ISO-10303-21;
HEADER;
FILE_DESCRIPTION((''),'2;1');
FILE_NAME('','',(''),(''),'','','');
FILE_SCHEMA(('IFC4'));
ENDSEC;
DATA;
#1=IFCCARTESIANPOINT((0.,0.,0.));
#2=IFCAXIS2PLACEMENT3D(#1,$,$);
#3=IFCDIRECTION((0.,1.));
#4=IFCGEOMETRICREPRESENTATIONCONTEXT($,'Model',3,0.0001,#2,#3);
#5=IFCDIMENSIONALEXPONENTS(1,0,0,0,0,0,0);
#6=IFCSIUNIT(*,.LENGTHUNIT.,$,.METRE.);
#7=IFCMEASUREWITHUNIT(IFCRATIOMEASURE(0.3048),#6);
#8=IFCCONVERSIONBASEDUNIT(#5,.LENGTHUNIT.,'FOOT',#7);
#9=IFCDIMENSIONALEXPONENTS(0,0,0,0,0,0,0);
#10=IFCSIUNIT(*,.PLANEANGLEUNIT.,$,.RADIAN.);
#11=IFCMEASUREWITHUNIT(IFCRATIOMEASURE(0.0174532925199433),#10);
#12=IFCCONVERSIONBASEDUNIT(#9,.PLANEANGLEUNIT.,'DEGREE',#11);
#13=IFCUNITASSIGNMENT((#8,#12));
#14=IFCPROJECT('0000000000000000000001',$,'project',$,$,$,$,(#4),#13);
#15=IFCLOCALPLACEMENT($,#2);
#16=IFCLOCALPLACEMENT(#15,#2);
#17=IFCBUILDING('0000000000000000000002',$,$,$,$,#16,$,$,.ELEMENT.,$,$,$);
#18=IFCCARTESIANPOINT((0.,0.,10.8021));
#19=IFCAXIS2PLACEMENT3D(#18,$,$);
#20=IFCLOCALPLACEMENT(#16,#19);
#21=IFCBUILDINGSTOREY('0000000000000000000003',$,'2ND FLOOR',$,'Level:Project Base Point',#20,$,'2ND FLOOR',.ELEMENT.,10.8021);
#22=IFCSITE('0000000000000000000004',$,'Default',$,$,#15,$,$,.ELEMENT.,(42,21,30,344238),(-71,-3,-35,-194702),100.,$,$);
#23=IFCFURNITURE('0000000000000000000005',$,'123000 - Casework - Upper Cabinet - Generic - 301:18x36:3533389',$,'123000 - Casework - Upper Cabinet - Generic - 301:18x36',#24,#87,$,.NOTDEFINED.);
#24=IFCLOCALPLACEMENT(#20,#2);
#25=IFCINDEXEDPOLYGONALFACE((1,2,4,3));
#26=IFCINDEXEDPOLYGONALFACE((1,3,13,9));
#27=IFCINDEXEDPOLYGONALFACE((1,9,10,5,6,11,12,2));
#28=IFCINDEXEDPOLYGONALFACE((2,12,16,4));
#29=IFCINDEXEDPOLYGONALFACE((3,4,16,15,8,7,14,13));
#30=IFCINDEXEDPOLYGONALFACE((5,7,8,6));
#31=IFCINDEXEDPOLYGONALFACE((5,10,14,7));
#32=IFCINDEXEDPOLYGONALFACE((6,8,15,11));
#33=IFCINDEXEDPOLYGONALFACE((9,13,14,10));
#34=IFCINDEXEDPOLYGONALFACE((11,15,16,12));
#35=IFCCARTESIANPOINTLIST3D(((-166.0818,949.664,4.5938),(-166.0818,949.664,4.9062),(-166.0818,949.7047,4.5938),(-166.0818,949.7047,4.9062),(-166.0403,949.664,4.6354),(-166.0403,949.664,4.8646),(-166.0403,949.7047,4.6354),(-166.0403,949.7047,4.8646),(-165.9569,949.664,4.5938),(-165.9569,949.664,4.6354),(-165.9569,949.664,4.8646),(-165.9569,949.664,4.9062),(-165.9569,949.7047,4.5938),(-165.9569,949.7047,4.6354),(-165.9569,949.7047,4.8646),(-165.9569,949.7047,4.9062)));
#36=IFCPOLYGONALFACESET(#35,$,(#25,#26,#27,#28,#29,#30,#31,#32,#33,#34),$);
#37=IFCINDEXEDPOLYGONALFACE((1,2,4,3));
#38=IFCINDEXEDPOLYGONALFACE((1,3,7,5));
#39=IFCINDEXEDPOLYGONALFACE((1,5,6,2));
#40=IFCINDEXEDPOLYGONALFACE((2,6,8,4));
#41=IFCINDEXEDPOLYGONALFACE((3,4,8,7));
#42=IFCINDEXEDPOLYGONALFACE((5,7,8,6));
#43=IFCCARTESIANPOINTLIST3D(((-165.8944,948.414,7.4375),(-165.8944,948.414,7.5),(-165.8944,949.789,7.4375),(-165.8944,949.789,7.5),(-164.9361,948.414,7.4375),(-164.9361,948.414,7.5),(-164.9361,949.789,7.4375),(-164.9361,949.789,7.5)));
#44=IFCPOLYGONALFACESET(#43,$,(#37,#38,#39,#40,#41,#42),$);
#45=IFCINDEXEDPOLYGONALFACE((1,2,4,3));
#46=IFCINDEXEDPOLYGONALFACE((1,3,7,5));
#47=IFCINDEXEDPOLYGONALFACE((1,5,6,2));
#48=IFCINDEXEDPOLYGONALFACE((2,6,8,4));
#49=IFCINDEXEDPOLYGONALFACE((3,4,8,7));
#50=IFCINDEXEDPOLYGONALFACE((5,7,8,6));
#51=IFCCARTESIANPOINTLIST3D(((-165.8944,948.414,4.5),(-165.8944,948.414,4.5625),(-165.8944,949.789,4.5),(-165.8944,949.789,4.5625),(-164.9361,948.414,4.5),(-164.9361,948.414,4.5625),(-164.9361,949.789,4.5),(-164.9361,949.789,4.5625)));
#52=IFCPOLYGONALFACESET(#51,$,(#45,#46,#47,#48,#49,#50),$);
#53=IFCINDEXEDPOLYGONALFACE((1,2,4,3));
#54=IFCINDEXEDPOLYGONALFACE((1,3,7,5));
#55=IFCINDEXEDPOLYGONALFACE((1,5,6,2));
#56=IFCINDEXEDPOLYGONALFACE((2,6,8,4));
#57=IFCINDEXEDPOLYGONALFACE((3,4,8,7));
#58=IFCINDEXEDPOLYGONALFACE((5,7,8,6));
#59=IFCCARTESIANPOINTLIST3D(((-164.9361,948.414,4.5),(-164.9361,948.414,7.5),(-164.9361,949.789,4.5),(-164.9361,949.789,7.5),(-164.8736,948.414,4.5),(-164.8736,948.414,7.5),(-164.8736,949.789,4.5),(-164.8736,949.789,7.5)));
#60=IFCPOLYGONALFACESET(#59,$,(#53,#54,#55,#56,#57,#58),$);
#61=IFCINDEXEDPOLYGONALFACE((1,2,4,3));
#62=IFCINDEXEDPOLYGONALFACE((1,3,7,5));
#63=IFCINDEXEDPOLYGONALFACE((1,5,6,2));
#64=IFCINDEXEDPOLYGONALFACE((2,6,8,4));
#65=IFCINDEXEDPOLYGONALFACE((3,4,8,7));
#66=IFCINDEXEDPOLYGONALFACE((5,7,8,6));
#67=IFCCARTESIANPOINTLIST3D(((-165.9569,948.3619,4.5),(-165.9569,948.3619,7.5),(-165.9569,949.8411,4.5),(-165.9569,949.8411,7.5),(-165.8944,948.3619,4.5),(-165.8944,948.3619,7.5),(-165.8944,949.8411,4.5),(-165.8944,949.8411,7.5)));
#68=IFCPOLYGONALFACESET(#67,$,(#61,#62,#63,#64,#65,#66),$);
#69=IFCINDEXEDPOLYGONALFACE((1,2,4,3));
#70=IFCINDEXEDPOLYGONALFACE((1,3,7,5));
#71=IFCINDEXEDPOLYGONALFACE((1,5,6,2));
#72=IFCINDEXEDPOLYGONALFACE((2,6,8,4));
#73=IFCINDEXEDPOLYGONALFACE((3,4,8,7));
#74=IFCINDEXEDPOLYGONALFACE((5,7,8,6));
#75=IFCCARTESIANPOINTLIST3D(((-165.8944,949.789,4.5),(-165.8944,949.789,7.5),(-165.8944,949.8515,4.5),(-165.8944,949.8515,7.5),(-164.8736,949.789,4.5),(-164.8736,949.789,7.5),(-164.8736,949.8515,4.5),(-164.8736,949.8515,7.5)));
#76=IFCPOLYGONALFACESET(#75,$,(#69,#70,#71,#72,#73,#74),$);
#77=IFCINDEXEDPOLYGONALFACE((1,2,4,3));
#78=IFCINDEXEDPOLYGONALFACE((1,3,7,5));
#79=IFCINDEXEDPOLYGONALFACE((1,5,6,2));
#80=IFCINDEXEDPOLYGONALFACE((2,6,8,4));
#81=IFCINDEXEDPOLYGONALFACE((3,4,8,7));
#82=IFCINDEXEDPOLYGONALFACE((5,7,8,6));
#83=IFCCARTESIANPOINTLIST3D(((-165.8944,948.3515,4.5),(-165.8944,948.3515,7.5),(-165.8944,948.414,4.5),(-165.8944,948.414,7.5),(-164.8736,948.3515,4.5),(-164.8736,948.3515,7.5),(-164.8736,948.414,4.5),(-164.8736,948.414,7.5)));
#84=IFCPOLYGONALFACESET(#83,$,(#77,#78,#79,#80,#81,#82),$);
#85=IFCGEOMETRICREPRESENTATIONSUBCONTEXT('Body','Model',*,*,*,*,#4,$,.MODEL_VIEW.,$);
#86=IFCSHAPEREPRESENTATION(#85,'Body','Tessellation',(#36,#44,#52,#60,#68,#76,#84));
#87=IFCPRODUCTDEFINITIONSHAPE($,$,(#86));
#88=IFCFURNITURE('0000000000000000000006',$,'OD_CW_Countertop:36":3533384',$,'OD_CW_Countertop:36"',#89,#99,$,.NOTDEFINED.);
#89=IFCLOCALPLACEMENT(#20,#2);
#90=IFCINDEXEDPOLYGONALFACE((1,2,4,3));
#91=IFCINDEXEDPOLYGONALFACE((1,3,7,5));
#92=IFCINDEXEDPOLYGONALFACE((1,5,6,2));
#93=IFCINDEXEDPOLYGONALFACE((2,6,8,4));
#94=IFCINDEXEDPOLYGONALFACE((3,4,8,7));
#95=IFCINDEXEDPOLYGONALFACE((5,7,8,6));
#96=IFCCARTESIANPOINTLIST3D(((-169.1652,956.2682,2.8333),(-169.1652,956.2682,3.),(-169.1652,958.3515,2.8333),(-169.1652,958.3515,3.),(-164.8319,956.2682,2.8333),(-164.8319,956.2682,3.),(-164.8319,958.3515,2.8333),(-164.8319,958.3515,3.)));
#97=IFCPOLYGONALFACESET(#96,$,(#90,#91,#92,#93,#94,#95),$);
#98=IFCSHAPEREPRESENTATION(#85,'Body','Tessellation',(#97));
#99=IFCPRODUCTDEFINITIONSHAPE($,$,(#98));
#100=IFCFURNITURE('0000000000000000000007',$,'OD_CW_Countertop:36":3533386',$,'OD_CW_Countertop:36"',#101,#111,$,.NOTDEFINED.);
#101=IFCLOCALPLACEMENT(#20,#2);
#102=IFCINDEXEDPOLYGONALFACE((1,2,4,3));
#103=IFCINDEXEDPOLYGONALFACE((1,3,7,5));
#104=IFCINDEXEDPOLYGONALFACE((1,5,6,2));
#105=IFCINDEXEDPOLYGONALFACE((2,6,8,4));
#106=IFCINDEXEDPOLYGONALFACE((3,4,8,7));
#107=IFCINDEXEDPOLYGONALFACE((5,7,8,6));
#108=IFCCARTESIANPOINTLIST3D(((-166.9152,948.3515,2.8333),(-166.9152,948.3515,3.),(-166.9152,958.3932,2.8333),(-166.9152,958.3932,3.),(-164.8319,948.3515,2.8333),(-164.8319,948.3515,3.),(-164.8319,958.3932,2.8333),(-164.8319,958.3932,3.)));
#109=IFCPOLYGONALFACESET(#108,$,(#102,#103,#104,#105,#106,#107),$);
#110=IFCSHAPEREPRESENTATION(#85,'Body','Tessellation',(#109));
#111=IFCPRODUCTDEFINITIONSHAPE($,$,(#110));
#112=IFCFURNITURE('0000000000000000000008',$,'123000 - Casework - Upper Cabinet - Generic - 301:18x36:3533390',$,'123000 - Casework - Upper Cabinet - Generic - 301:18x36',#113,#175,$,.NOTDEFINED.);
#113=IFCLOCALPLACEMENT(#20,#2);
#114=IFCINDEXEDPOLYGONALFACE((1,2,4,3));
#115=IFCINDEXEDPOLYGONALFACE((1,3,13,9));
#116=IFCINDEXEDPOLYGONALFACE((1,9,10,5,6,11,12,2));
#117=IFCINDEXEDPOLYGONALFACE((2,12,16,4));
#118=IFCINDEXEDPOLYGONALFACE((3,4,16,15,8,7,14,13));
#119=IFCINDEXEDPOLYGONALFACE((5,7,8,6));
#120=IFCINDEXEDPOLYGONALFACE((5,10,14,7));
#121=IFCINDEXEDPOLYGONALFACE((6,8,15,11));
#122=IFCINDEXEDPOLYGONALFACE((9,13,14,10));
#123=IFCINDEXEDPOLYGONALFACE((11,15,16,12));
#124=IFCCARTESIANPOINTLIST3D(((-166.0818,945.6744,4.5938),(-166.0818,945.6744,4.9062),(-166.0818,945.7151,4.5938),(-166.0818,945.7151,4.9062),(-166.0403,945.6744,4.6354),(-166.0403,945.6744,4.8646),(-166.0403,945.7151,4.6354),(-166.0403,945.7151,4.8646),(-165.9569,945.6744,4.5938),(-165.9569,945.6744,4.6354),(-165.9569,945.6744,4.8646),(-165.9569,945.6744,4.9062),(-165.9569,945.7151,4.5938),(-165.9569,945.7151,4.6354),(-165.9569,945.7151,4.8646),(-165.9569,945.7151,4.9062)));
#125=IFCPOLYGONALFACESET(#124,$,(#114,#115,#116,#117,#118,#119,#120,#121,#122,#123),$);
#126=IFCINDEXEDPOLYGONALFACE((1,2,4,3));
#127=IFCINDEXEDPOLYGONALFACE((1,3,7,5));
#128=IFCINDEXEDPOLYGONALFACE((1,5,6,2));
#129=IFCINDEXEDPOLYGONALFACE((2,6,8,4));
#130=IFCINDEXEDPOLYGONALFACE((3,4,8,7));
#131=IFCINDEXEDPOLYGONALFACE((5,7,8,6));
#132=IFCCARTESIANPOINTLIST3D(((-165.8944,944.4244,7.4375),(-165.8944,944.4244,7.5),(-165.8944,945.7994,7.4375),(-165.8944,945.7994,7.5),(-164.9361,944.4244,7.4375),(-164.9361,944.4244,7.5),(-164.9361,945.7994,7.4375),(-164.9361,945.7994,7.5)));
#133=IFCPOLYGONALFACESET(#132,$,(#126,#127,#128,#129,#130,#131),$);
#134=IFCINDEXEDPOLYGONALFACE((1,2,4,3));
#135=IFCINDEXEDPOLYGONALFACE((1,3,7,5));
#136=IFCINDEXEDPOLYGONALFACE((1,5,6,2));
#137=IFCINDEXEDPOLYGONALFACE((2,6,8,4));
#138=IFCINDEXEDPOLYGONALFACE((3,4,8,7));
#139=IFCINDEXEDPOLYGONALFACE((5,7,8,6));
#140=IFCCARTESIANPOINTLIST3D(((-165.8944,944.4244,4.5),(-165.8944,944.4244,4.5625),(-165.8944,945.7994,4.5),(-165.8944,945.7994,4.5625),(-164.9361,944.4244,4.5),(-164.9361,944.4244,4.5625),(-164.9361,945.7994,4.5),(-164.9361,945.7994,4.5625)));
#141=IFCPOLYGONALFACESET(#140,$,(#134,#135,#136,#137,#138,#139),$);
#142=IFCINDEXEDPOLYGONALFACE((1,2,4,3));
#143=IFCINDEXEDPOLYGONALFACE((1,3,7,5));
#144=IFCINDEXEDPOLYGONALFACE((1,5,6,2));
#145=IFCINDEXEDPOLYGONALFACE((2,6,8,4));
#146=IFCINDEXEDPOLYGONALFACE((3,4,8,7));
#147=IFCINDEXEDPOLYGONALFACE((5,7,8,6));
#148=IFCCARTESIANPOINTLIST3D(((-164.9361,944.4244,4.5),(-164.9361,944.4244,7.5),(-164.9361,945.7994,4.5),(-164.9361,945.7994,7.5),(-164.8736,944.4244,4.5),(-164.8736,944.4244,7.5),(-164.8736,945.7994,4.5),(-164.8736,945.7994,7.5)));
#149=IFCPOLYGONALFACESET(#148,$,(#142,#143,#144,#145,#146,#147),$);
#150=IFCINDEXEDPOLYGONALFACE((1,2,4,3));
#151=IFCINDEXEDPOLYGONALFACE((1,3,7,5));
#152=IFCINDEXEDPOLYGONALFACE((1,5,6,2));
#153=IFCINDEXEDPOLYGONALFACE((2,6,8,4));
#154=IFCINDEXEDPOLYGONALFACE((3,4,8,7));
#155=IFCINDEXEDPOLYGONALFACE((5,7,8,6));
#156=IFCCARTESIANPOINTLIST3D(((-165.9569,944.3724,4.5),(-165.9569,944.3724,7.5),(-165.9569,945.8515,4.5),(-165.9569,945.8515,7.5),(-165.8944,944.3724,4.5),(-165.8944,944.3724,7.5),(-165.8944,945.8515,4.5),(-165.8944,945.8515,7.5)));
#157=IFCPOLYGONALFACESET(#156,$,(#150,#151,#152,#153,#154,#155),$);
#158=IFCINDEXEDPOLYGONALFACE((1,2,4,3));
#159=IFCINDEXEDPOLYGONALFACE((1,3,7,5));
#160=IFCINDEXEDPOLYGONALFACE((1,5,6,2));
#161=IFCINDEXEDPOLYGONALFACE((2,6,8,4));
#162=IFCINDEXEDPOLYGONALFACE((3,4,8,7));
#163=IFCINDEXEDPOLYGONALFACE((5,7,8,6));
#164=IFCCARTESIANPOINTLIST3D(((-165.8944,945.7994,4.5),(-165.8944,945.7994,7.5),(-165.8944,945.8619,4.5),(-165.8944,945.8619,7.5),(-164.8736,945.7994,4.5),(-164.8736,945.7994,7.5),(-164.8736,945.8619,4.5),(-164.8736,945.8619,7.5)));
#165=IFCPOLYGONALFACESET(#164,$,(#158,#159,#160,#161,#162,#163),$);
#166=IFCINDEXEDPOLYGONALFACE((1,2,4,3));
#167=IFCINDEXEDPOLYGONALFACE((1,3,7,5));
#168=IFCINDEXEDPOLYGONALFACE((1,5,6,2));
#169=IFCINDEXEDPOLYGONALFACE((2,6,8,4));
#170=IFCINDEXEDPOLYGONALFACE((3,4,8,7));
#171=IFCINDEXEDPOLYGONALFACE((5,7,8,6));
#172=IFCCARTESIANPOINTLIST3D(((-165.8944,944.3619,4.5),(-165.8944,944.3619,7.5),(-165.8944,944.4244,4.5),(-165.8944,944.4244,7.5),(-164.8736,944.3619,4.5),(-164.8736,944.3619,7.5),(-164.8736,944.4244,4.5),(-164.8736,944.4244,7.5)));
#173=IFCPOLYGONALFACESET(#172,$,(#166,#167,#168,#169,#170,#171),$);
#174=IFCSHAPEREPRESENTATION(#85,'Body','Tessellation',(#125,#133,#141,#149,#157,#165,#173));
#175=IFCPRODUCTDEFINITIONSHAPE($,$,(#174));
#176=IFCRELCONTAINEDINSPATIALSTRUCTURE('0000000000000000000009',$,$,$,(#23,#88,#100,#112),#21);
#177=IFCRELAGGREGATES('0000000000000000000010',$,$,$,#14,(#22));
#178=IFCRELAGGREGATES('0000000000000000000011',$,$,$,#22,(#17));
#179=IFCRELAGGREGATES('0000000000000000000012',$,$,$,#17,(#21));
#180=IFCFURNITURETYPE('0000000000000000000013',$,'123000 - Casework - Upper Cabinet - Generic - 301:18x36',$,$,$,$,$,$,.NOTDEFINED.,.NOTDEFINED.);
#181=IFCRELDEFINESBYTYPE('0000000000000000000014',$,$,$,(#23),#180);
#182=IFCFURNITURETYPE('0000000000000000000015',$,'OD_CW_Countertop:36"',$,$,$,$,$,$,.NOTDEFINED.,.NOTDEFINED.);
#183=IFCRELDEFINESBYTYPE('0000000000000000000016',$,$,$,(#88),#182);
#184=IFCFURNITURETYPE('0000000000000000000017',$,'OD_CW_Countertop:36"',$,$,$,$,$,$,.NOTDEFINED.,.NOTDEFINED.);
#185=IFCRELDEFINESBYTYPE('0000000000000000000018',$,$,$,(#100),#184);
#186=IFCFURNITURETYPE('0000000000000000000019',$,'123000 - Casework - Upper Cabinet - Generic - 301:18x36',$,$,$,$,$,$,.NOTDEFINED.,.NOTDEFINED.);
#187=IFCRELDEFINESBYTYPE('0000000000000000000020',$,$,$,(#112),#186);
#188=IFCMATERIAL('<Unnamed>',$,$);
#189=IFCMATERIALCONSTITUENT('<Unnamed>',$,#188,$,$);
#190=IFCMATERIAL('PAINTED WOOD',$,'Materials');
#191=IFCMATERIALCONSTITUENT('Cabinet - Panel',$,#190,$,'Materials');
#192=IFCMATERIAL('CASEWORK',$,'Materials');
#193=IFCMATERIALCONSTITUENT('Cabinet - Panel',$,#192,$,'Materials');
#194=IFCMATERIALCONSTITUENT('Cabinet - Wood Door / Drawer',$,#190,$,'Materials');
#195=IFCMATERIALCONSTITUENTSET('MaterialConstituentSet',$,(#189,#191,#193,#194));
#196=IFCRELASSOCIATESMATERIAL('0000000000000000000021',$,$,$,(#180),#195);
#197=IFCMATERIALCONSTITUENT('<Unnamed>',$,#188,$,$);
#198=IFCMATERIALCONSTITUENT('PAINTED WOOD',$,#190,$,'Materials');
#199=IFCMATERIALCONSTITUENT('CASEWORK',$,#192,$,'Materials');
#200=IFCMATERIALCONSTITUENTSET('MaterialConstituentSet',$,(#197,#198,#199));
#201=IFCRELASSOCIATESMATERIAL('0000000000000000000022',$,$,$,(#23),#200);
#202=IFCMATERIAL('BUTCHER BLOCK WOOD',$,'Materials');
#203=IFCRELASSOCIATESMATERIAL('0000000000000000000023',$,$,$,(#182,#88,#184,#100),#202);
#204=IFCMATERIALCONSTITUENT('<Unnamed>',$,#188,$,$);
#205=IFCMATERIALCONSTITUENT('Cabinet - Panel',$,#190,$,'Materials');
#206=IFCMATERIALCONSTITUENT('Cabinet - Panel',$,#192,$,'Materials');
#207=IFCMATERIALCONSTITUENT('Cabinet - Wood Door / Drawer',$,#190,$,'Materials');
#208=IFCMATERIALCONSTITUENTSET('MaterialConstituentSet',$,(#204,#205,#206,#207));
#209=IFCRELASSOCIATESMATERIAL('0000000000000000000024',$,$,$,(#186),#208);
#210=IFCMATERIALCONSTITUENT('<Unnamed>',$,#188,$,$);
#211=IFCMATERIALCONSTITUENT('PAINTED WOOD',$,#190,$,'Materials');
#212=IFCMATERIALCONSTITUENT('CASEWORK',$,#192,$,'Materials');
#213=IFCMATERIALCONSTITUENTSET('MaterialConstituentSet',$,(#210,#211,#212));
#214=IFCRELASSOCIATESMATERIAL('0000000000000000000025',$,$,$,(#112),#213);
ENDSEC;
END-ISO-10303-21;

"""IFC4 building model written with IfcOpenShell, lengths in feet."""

from ifc_helpers import new_model, entity, si_unit, converted_unit, direction, frame, frame_2d, origin, origin_2d_with_axis, place, context, subcontext, project, spatial, polyline, rectangle, outline, extrude, source, transform, mapped, material, constituent, constituent_set, type_object, type_shapes, element, save


model = new_model("IFC4")

# Units and contexts
model_context = context("Model", 3, precision=0.0001, world=origin(), true_north=direction((0.0, 1.0)))
body_context = subcontext(model_context, "Body", "Model", "MODEL_VIEW")
ifc_project = project(units=[converted_unit("LENGTHUNIT", "FOOT", entity("IfcRatioMeasure", 0.3048), si_unit("LENGTHUNIT", "METRE"), dimensions=[1, 0, 0, 0, 0, 0, 0]), converted_unit("PLANEANGLEUNIT", "DEGREE", entity("IfcRatioMeasure", 0.0174532925199433), si_unit("PLANEANGLEUNIT", "RADIAN"), dimensions=[0, 0, 0, 0, 0, 0, 0])], contexts=[model_context])

# Site, building, storey
site_placement = place(None, origin())
site = spatial("IfcSite", under=ifc_project, at=site_placement, Name="Default", CompositionType="ELEMENT", RefLatitude=(42, 21, 30, 344238), RefLongitude=(-71, -3, -35, -194702), RefElevation=100.0)
building_placement = place(site_placement, origin())
building = spatial("IfcBuilding", under=site, at=building_placement, CompositionType="ELEMENT")
storey_placement = place(building_placement, frame((0.0, 0.0, 10.8021)))
storey = spatial("IfcBuildingStorey", under=building, at=storey_placement, Name="2ND FLOOR", ObjectType="Level:Project Base Point", LongName="2ND FLOOR", CompositionType="ELEMENT", Elevation=10.8021)

# Shared definitions
ifc_material_1 = material(Name="PAINTED WOOD", Category="Materials")
ifc_material_2 = material(Name="CASEWORK", Category="Materials")

# Furniture
ifc_material_3 = material(Name="<Unnamed>")
ifc_constituent_1 = constituent(ifc_material_3, Name="<Unnamed>")
ifc_constituent_2 = constituent(ifc_material_1, Name="PAINTED WOOD", Category="Materials")
ifc_constituent_3 = constituent(ifc_material_2, Name="CASEWORK", Category="Materials")
ifc_constituent_set_1 = constituent_set(constituents=[ifc_constituent_1, ifc_constituent_2, ifc_constituent_3], Name="MaterialConstituentSet")
ifc_constituent_4 = constituent(ifc_material_3, Name="<Unnamed>")
ifc_constituent_5 = constituent(ifc_material_1, Name="Cabinet - Panel", Category="Materials")
ifc_constituent_6 = constituent(ifc_material_2, Name="Cabinet - Panel", Category="Materials")
ifc_constituent_7 = constituent(ifc_material_1, Name="Cabinet - Wood Door / Drawer", Category="Materials")
ifc_constituent_set_2 = constituent_set(constituents=[ifc_constituent_4, ifc_constituent_5, ifc_constituent_6, ifc_constituent_7], Name="MaterialConstituentSet")
furniture_type_1 = type_object("IfcFurnitureType", Name="123000 - Casework - Upper Cabinet - Generic - 301:18x36", AssemblyPlace="NOTDEFINED", PredefinedType="NOTDEFINED", material=ifc_constituent_set_2)
shared_shape_1 = source(origin(), body_context, "Body", "SweptSolid", [
    extrude(outline(polyline([(0.1146, -0.0521), (0.1562, -0.0521), (0.1562, 0.0729), (-0.1562, 0.0729), (-0.1562, -0.0521), (-0.1146, -0.0521), (-0.1146, 0.0313), (0.1146, 0.0313), (0.1146, -0.0521)])), frame((0.1468, 0.0729, 0.25), z_axis=(1.0, 0.0, 0.0), x_axis=(0.0, 0.0, 1.0)), (0.0, 0.0, 1.0), 0.0407),
    extrude(rectangle(XDim=1.375, YDim=0.9583, at=frame_2d((0.0, 0.0), x_axis=(1.0, 0.0))), frame((0.75, 0.6666, 2.9375), z_axis=(0.0, 0.0, 1.0), x_axis=(-1.0, 0.0, 0.0)), (0.0, 0.0, 1.0), 0.0625),
    extrude(rectangle(XDim=1.375, YDim=0.9583, at=frame_2d((0.0, 0.0), x_axis=(1.0, 0.0))), frame((0.75, 0.6666, 0.0), z_axis=(0.0, 0.0, 1.0), x_axis=(-1.0, 0.0, 0.0)), (0.0, 0.0, 1.0), 0.0625),
    extrude(rectangle(XDim=0.0625, YDim=1.375, at=origin_2d_with_axis()), frame((0.75, 1.177, 0.0), z_axis=(0.0, 0.0, 1.0), x_axis=(0.0, 1.0, 0.0)), (0.0, 0.0, 1.0), 3.0),
    extrude(rectangle(XDim=0.0625, YDim=1.4792, at=origin_2d_with_axis()), frame((0.75, 0.1562, 0.0), z_axis=(0.0, 0.0, 1.0), x_axis=(0.0, -1.0, 0.0)), (0.0, 0.0, 1.0), 3.0),
    extrude(rectangle(XDim=0.0625, YDim=1.0208, at=origin_2d_with_axis()), frame((0.0312, 0.6979, 0.0), z_axis=(0.0, 0.0, 1.0), x_axis=(-1.0, 0.0, 0.0)), (0.0, 0.0, 1.0), 3.0),
    extrude(rectangle(XDim=0.0625, YDim=1.0208, at=origin_2d_with_axis()), frame((1.4688, 0.6979, 0.0), z_axis=(0.0, 0.0, 1.0), x_axis=(-1.0, 0.0, 0.0)), (0.0, 0.0, 1.0), 3.0),
])
type_shapes(furniture_type_1, [shared_shape_1])
furniture_1_placement = place(storey_placement, frame((-166.0818, 949.8515, 4.5), z_axis=(0.0, 0.0, 1.0), x_axis=(0.0, -1.0, 0.0)))
element("IfcFurniture", 1, at=furniture_1_placement, inside=storey, type_object=furniture_type_1, material=ifc_constituent_set_1, Name="123000 - Casework - Upper Cabinet - Generic - 301:18x36:3533389", ObjectType="123000 - Casework - Upper Cabinet - Generic - 301:18x36", PredefinedType="NOTDEFINED", context=body_context, shape_type="MappedRepresentation", body=[
    mapped(shared_shape_1, transform((0.0, 0.0, 0.0), scale=1.0)),
])
ifc_material_4 = material(Name="BUTCHER BLOCK WOOD", Category="Materials")
furniture_type_2 = type_object("IfcFurnitureType", Name="OD_CW_Countertop:36\"", AssemblyPlace="NOTDEFINED", PredefinedType="NOTDEFINED", material=ifc_material_4)
shared_shape_2 = source(origin(), body_context, "Body", "SweptSolid", [
    extrude(rectangle(XDim=2.0833, YDim=4.3333, at=frame_2d((0.0, 0.0), x_axis=(1.0, 0.0))), frame((2.1667, 1.0417, 0.0), z_axis=(0.0, 0.0, 1.0), x_axis=(0.0, -1.0, 0.0)), (0.0, 0.0, 1.0), 0.1667),
])
type_shapes(furniture_type_2, [shared_shape_2])
furniture_2_placement = place(storey_placement, frame((-169.1652, 956.2682, 2.8333)))
element("IfcFurniture", 2, at=furniture_2_placement, inside=storey, type_object=furniture_type_2, material=ifc_material_4, Name="OD_CW_Countertop:36\":3533384", ObjectType="OD_CW_Countertop:36\"", PredefinedType="NOTDEFINED", context=body_context, shape_type="MappedRepresentation", body=[
    mapped(shared_shape_2, transform((0.0, 0.0, 0.0), scale=1.0)),
])
furniture_type_3 = type_object("IfcFurnitureType", Name="OD_CW_Countertop:36\"", AssemblyPlace="NOTDEFINED", PredefinedType="NOTDEFINED", material=ifc_material_4)
shared_shape_3 = source(origin(), body_context, "Body", "SweptSolid", [
    extrude(rectangle(XDim=2.0833, YDim=10.0417, at=origin_2d_with_axis()), frame((5.0208, 1.0417, 0.0), z_axis=(0.0, 0.0, 1.0), x_axis=(0.0, -1.0, 0.0)), (0.0, 0.0, 1.0), 0.1667),
])
type_shapes(furniture_type_3, [shared_shape_3])
furniture_3_placement = place(storey_placement, frame((-166.9152, 958.3932, 2.8333), z_axis=(0.0, 0.0, 1.0), x_axis=(0.0, -1.0, 0.0)))
element("IfcFurniture", 3, at=furniture_3_placement, inside=storey, type_object=furniture_type_3, material=ifc_material_4, Name="OD_CW_Countertop:36\":3533386", ObjectType="OD_CW_Countertop:36\"", PredefinedType="NOTDEFINED", context=body_context, shape_type="MappedRepresentation", body=[
    mapped(shared_shape_3, transform((0.0, 0.0, 0.0), scale=1.0)),
])
ifc_constituent_8 = constituent(ifc_material_3, Name="<Unnamed>")
ifc_constituent_9 = constituent(ifc_material_1, Name="PAINTED WOOD", Category="Materials")
ifc_constituent_10 = constituent(ifc_material_2, Name="CASEWORK", Category="Materials")
ifc_constituent_set_3 = constituent_set(constituents=[ifc_constituent_8, ifc_constituent_9, ifc_constituent_10], Name="MaterialConstituentSet")
ifc_constituent_11 = constituent(ifc_material_3, Name="<Unnamed>")
ifc_constituent_12 = constituent(ifc_material_1, Name="Cabinet - Panel", Category="Materials")
ifc_constituent_13 = constituent(ifc_material_2, Name="Cabinet - Panel", Category="Materials")
ifc_constituent_14 = constituent(ifc_material_1, Name="Cabinet - Wood Door / Drawer", Category="Materials")
ifc_constituent_set_4 = constituent_set(constituents=[ifc_constituent_11, ifc_constituent_12, ifc_constituent_13, ifc_constituent_14], Name="MaterialConstituentSet")
furniture_type_4 = type_object("IfcFurnitureType", Name="123000 - Casework - Upper Cabinet - Generic - 301:18x36", AssemblyPlace="NOTDEFINED", PredefinedType="NOTDEFINED", material=ifc_constituent_set_4)
shared_shape_4 = source(origin(), body_context, "Body", "SweptSolid", [
    extrude(outline(polyline([(0.1146, -0.0521), (0.1562, -0.0521), (0.1562, 0.0729), (-0.1562, 0.0729), (-0.1562, -0.0521), (-0.1146, -0.0521), (-0.1146, 0.0313), (0.1146, 0.0313), (0.1146, -0.0521)])), frame((0.1468, 0.0729, 0.25), z_axis=(1.0, 0.0, 0.0), x_axis=(0.0, 0.0, 1.0)), (0.0, 0.0, 1.0), 0.0407),
    extrude(rectangle(XDim=1.375, YDim=0.9583, at=frame_2d((0.0, 0.0), x_axis=(1.0, 0.0))), frame((0.75, 0.6666, 2.9375), z_axis=(0.0, 0.0, 1.0), x_axis=(-1.0, 0.0, 0.0)), (0.0, 0.0, 1.0), 0.0625),
    extrude(rectangle(XDim=1.375, YDim=0.9583, at=frame_2d((0.0, 0.0), x_axis=(1.0, 0.0))), frame((0.75, 0.6666, 0.0), z_axis=(0.0, 0.0, 1.0), x_axis=(-1.0, 0.0, 0.0)), (0.0, 0.0, 1.0), 0.0625),
    extrude(rectangle(XDim=0.0625, YDim=1.375, at=origin_2d_with_axis()), frame((0.75, 1.177, 0.0), z_axis=(0.0, 0.0, 1.0), x_axis=(0.0, 1.0, 0.0)), (0.0, 0.0, 1.0), 3.0),
    extrude(rectangle(XDim=0.0625, YDim=1.4792, at=origin_2d_with_axis()), frame((0.75, 0.1562, 0.0), z_axis=(0.0, 0.0, 1.0), x_axis=(0.0, -1.0, 0.0)), (0.0, 0.0, 1.0), 3.0),
    extrude(rectangle(XDim=0.0625, YDim=1.0208, at=origin_2d_with_axis()), frame((0.0312, 0.6979, 0.0), z_axis=(0.0, 0.0, 1.0), x_axis=(-1.0, 0.0, 0.0)), (0.0, 0.0, 1.0), 3.0),
    extrude(rectangle(XDim=0.0625, YDim=1.0208, at=origin_2d_with_axis()), frame((1.4688, 0.6979, 0.0), z_axis=(0.0, 0.0, 1.0), x_axis=(-1.0, 0.0, 0.0)), (0.0, 0.0, 1.0), 3.0),
])
type_shapes(furniture_type_4, [shared_shape_4])
furniture_4_placement = place(storey_placement, frame((-166.0818, 945.8619, 4.5), z_axis=(0.0, 0.0, 1.0), x_axis=(0.0, -1.0, 0.0)))
element("IfcFurniture", 4, at=furniture_4_placement, inside=storey, type_object=furniture_type_4, material=ifc_constituent_set_3, Name="123000 - Casework - Upper Cabinet - Generic - 301:18x36:3533390", ObjectType="123000 - Casework - Upper Cabinet - Generic - 301:18x36", PredefinedType="NOTDEFINED", context=body_context, shape_type="MappedRepresentation", body=[
    mapped(shared_shape_4, transform((0.0, 0.0, 0.0), scale=1.0)),
])

save(model, "model.ifc")
